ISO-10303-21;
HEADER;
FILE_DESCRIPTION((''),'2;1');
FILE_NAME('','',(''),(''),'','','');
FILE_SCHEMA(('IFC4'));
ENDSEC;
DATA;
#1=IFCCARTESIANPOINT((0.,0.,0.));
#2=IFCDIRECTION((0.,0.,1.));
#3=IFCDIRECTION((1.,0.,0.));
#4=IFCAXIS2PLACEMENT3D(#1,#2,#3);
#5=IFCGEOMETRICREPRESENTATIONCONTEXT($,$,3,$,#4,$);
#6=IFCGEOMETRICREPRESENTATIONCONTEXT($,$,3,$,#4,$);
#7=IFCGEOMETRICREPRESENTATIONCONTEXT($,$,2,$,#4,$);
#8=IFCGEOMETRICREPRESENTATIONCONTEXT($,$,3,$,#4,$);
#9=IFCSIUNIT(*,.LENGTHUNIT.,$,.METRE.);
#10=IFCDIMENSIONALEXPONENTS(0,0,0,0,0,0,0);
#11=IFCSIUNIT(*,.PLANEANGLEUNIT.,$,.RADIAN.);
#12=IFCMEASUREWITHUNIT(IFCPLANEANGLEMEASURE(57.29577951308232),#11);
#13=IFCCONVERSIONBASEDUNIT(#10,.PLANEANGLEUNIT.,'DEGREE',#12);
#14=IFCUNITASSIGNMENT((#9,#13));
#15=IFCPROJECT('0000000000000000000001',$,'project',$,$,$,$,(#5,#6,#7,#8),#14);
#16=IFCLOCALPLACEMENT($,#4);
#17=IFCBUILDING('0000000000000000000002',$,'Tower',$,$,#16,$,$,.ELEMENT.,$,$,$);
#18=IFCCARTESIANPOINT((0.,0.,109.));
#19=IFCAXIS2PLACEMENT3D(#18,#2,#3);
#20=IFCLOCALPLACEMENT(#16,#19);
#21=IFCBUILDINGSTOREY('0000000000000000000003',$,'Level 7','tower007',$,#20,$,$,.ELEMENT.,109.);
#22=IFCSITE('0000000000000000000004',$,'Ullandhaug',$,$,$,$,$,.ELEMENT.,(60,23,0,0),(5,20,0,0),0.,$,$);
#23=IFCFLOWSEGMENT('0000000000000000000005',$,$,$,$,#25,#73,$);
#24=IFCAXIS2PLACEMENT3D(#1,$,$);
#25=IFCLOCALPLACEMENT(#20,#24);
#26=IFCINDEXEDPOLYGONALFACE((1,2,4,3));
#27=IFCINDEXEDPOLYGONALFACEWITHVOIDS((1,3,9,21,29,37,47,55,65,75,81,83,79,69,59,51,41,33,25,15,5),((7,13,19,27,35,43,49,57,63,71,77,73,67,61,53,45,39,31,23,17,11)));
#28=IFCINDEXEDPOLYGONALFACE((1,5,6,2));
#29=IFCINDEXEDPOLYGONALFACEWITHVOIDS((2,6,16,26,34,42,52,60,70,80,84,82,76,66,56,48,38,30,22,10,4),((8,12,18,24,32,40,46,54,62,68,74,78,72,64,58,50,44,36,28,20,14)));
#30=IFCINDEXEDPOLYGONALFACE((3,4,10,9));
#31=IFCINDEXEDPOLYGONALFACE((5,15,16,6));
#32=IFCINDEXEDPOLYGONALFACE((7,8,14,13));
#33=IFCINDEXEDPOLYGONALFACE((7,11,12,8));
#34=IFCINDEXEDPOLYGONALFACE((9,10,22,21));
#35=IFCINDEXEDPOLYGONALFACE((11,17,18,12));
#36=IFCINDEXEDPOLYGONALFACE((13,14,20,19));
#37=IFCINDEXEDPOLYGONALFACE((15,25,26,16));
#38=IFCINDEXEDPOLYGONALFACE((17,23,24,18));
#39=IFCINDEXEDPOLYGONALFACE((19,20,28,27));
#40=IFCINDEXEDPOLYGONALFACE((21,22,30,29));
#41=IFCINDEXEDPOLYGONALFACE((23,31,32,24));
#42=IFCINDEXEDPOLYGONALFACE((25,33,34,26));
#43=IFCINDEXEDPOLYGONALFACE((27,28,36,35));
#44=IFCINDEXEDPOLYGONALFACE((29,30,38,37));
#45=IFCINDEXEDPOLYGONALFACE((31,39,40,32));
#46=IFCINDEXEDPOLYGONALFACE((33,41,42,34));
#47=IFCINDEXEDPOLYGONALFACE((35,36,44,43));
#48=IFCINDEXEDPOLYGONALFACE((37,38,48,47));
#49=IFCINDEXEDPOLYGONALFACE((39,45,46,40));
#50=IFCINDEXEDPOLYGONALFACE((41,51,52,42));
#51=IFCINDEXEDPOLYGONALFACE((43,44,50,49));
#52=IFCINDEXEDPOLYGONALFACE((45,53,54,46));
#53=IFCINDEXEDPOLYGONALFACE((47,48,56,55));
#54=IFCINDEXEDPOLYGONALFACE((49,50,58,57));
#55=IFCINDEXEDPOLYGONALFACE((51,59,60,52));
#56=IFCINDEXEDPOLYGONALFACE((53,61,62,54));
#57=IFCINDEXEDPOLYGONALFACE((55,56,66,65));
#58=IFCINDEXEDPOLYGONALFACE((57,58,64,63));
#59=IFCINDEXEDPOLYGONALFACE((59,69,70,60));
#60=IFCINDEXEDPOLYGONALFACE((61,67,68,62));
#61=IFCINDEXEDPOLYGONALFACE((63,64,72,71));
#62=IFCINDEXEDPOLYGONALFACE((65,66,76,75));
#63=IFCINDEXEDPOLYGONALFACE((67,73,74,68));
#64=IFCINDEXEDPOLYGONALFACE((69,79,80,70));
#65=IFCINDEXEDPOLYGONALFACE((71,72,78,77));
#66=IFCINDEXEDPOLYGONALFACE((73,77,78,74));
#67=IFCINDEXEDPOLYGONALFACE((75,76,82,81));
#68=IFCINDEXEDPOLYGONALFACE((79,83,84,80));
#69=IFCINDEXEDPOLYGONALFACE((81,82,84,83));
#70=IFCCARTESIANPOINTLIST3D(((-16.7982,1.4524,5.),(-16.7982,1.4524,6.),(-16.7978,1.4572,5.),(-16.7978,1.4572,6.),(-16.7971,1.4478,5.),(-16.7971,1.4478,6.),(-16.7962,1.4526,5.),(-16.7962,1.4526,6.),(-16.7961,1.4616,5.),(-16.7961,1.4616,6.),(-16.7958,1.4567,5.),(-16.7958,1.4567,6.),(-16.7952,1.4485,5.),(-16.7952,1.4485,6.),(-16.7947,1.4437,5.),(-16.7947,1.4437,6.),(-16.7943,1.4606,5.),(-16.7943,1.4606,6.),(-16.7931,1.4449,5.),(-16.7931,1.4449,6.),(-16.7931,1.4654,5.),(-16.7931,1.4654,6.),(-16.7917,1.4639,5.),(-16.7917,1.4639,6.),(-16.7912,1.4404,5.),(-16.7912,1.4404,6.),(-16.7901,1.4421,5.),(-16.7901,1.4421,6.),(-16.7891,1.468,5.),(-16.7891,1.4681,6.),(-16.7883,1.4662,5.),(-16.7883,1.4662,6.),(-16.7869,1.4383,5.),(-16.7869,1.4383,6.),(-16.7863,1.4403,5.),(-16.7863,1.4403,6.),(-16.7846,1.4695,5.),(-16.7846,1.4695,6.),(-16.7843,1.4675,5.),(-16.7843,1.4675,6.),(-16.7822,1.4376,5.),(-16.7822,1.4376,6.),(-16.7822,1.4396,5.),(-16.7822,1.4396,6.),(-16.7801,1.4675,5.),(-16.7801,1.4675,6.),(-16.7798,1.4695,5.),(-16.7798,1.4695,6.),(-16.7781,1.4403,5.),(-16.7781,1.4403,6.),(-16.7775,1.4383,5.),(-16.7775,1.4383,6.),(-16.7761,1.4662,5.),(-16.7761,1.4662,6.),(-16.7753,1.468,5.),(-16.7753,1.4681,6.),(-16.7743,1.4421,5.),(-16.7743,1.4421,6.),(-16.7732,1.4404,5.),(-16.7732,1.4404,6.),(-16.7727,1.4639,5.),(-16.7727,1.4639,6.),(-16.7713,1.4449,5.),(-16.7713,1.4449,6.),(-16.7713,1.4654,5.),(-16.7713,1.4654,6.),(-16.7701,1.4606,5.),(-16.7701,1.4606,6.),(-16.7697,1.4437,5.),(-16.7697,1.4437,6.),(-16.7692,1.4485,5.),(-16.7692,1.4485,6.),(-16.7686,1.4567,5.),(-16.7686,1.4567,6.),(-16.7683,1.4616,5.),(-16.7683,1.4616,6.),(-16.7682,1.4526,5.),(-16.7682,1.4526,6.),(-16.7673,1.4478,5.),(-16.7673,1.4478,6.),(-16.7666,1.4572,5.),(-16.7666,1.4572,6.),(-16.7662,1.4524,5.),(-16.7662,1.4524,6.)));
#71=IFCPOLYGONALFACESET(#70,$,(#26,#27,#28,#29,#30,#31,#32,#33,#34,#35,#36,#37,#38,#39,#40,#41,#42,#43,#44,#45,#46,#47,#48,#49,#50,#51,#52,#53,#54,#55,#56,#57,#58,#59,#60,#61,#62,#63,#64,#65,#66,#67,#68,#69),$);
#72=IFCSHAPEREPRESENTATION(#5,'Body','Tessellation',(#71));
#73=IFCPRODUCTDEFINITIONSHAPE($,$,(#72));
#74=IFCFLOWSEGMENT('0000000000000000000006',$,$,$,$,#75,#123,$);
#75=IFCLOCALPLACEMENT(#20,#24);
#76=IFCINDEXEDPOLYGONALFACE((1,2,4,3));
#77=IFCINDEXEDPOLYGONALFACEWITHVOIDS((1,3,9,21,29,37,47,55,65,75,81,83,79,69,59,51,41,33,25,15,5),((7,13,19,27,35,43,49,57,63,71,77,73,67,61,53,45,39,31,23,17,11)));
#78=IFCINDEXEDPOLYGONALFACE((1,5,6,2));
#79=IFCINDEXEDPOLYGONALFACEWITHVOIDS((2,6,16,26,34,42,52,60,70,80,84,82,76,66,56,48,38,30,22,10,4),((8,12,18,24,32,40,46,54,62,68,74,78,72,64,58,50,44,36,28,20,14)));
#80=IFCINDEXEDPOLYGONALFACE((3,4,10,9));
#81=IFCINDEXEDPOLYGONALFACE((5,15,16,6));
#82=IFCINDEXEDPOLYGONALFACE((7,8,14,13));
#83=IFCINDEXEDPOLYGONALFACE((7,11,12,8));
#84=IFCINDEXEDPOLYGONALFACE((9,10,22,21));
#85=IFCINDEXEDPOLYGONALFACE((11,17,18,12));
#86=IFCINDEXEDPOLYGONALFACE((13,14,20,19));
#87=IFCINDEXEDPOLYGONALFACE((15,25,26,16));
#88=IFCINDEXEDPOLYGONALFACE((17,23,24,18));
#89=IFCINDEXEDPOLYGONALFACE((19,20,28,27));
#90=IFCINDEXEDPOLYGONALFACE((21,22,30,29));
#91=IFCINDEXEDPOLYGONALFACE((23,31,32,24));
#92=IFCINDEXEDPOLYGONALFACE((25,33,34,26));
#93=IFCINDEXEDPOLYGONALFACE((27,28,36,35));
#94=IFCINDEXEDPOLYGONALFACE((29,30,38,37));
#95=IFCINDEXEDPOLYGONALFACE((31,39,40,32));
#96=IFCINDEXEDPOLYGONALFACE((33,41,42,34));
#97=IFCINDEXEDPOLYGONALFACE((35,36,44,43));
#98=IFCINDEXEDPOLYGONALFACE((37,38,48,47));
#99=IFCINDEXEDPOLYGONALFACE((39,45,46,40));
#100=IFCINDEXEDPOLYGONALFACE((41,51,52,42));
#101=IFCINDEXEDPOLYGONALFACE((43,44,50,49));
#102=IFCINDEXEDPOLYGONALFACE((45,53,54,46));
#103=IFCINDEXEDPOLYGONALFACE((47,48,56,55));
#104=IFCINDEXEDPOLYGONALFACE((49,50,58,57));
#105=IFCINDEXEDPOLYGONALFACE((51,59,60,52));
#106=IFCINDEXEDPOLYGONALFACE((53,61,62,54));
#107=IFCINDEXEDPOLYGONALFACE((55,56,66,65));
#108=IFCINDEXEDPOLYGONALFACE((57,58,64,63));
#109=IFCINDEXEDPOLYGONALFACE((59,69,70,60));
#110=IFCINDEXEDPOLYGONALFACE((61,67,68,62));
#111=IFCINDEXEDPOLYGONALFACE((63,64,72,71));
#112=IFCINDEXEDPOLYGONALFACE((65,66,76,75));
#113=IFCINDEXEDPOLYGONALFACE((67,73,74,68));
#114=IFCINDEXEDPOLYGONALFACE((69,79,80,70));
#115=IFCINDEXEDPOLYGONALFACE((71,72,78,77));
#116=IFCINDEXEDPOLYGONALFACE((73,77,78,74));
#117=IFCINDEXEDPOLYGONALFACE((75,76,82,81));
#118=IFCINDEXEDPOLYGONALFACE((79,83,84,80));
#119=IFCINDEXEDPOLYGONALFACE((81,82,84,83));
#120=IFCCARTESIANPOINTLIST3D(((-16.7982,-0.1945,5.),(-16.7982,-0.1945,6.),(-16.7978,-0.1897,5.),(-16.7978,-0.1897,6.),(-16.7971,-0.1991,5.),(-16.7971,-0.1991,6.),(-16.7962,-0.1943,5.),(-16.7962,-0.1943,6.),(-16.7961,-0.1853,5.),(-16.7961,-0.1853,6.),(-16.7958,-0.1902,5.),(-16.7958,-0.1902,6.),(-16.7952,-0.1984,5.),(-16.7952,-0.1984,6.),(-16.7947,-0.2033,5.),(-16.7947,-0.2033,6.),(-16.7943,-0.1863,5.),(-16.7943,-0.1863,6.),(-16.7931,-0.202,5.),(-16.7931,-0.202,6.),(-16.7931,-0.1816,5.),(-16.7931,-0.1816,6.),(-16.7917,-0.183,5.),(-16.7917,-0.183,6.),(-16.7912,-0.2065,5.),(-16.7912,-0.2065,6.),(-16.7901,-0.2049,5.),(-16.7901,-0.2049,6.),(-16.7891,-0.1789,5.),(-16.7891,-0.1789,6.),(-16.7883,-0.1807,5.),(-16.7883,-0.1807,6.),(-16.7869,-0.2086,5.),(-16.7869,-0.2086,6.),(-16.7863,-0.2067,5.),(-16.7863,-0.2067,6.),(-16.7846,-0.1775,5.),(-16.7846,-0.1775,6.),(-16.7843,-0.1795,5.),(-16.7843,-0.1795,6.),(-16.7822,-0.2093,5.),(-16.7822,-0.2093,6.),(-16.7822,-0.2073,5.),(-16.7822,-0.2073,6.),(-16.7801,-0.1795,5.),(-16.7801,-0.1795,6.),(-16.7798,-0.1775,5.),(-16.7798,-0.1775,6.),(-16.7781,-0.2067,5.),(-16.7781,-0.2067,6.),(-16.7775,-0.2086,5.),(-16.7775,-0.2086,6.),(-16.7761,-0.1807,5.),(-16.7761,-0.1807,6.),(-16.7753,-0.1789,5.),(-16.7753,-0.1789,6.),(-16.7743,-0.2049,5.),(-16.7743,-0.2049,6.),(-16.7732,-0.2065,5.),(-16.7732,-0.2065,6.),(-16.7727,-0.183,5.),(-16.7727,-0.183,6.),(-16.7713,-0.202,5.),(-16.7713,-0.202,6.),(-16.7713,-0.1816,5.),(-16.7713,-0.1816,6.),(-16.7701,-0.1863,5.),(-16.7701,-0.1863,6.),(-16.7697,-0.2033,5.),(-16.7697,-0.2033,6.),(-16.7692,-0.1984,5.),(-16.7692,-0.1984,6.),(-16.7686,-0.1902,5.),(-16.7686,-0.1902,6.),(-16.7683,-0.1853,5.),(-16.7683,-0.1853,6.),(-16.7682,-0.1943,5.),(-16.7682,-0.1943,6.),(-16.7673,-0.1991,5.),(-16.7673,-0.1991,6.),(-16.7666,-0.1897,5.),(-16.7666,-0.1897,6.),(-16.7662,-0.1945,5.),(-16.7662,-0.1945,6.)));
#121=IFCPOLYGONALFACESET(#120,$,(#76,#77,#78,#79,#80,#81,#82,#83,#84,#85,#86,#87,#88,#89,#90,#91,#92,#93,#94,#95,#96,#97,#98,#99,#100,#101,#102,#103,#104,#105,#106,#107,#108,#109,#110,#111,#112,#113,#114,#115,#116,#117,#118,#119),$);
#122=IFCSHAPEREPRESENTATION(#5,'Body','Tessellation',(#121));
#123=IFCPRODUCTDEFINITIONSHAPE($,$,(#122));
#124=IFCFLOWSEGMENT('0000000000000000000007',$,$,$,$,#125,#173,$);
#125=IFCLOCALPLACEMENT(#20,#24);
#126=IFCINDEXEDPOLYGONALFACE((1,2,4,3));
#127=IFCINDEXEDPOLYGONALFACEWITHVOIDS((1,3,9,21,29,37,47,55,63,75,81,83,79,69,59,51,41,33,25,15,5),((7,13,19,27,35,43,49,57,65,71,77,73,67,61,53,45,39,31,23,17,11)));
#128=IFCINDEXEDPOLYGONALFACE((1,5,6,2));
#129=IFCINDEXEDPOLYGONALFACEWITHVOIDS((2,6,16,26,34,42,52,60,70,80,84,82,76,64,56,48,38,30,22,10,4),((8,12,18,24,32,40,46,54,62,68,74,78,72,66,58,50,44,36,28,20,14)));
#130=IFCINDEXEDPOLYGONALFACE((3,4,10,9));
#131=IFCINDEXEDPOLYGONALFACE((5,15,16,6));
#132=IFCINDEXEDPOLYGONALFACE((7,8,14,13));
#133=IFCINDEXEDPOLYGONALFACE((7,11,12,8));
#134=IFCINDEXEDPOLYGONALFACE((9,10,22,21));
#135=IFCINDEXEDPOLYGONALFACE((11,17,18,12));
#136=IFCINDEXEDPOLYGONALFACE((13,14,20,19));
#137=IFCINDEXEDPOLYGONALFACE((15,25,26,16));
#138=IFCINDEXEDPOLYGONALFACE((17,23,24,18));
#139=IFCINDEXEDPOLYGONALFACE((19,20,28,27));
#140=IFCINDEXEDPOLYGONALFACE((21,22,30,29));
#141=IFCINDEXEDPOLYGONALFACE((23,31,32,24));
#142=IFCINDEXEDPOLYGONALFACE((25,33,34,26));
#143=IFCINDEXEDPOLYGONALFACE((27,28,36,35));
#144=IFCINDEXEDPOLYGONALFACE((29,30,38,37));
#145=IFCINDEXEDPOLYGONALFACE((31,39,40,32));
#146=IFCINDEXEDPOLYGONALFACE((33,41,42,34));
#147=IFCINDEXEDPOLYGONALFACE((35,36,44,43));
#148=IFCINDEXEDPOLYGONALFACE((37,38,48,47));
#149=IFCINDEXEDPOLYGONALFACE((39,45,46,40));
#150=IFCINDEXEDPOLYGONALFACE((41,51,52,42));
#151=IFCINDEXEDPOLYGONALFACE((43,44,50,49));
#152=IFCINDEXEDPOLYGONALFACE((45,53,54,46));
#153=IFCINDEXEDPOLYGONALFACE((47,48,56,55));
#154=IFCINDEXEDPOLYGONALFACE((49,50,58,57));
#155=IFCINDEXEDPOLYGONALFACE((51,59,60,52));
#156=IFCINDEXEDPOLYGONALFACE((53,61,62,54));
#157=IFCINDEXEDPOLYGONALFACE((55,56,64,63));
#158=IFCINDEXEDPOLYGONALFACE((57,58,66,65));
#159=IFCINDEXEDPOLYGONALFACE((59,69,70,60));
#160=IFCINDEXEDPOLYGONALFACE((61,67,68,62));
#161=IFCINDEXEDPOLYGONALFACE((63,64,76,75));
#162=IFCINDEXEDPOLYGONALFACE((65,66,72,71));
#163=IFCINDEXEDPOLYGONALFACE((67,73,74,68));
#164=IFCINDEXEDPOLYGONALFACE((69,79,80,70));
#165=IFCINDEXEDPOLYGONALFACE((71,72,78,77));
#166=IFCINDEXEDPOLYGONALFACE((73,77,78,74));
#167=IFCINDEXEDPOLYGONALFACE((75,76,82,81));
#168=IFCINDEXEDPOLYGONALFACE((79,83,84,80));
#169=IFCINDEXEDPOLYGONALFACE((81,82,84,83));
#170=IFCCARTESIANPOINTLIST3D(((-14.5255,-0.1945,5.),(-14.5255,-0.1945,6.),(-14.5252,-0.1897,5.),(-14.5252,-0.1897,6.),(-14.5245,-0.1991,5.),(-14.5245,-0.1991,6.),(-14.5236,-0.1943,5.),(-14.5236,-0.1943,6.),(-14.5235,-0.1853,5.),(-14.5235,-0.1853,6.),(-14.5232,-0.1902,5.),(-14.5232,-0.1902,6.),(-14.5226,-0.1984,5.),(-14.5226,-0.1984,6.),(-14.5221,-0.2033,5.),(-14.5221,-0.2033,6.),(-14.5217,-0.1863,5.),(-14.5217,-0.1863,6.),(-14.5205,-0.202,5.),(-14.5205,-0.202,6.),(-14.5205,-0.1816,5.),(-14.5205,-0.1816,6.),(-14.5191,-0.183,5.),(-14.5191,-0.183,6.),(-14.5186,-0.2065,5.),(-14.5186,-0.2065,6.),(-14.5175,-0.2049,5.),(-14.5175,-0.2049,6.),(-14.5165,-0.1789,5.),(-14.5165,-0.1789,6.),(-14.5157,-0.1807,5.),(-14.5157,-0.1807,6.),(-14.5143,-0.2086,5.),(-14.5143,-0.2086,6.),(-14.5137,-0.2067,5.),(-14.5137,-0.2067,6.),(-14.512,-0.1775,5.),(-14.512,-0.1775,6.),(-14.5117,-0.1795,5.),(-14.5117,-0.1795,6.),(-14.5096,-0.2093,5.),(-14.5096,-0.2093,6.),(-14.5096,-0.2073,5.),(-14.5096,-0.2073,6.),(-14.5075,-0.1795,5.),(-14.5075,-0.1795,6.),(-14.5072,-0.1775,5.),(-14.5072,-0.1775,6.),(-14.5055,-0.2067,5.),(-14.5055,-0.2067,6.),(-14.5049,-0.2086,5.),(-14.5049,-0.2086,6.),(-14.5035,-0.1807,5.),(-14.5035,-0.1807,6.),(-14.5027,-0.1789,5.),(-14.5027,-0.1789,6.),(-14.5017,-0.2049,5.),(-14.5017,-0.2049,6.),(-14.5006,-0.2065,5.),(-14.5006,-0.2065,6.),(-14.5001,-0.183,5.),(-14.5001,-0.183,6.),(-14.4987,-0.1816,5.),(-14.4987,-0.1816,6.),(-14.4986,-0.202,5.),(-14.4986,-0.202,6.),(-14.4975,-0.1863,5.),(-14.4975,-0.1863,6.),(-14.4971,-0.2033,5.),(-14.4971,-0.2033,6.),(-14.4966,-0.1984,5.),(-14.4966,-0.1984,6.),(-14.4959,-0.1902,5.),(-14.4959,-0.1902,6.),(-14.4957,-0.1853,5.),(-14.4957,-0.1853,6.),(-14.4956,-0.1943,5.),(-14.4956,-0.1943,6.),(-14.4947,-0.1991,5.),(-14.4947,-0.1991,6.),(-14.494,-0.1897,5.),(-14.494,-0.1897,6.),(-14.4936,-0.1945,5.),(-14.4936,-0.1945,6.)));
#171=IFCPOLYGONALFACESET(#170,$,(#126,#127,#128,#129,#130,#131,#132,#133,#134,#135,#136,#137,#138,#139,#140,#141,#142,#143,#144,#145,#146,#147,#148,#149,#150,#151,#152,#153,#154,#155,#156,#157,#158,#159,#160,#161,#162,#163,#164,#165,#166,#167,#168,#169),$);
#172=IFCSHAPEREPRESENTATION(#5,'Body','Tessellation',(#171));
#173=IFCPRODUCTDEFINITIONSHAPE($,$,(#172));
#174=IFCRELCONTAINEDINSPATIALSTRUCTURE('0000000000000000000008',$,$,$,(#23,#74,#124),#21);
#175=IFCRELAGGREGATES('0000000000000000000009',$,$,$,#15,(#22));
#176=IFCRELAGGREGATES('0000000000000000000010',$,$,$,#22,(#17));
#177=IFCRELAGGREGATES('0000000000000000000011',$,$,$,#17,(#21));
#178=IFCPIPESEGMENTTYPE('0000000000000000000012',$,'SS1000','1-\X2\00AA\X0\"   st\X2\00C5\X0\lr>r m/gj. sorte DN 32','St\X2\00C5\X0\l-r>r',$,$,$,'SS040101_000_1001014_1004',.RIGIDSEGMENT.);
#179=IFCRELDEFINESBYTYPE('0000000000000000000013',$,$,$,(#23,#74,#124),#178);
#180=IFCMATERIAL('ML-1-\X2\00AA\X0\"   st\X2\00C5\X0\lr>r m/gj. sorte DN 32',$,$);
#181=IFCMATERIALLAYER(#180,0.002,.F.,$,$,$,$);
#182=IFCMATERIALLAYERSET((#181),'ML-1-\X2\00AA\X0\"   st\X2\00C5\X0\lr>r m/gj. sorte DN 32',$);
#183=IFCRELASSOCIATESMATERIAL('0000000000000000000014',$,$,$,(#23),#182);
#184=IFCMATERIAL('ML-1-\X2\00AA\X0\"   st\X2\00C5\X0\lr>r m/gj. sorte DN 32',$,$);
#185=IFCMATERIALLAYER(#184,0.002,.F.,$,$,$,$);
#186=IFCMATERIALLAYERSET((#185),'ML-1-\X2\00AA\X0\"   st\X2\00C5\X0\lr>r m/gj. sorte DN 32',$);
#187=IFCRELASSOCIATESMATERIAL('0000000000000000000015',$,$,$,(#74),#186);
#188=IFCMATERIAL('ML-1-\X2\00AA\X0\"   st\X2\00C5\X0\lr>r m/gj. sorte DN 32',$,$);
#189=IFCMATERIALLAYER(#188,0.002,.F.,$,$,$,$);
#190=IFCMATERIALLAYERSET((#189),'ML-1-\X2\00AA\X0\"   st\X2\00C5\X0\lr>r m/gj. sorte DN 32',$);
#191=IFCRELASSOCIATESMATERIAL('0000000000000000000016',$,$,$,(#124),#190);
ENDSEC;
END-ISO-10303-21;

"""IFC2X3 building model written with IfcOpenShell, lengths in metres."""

from ifc_helpers import new_model, entity, si_unit, converted_unit, frame, origin_with_axes, origin_2d_with_axis, place, context, project, spatial, hollow_circle, extrude, material, layer, layer_set, layer_usage, type_object, element, save


model = new_model("IFC2X3")

# Units and contexts
context_of_model_1 = context(None, 3, world=origin_with_axes())
context_of_model_2 = context(None, 3, world=origin_with_axes())
context_of_model_3 = context(None, 2, world=origin_with_axes())
context_of_model_4 = context(None, 3, world=origin_with_axes())
ifc_project = project(units=[si_unit("LENGTHUNIT", "METRE"), converted_unit("PLANEANGLEUNIT", "DEGREE", entity("IfcPlaneAngleMeasure", 57.29577951308232), si_unit("PLANEANGLEUNIT", "RADIAN"), dimensions=[0, 0, 0, 0, 0, 0, 0])], contexts=[context_of_model_1, context_of_model_2, context_of_model_3, context_of_model_4])

# Site, building, storey
site = spatial("IfcSite", under=ifc_project, Name="Ullandhaug", CompositionType="ELEMENT", RefLatitude=(60, 23, 0, 0), RefLongitude=(5, 20, 0, 0), RefElevation=0.0)
building_placement = place(None, origin_with_axes())
building = spatial("IfcBuilding", under=site, at=building_placement, Name="Tower", CompositionType="ELEMENT")
storey_placement = place(building_placement, frame((0.0, 0.0, 109.0), z_axis=(0.0, 0.0, 1.0), x_axis=(1.0, 0.0, 0.0)))
storey = spatial("IfcBuildingStorey", under=building, at=storey_placement, Name="Level 7", Description="tower007", CompositionType="ELEMENT", Elevation=109.0)

# Flow segments
pipe_segment_type_1 = type_object("IfcPipeSegmentType", Name="SS1000", Description="1-ª\"   stÅlr>r m/gj. sorte DN 32", ApplicableOccurrence="StÅl-r>r", ElementType="SS040101_000_1001014_1004", PredefinedType="RIGIDSEGMENT")
ifc_material_1 = material(Name="ML-1-ª\"   stÅlr>r m/gj. sorte DN 32")
ifc_layer_1 = layer(ifc_material_1, 0.002, ventilated=False)
ifc_layer_set_1 = layer_set([ifc_layer_1], Name="ML-1-ª\"   stÅlr>r m/gj. sorte DN 32")
ifc_layer_usage_1 = layer_usage(ifc_layer_set_1, "AXIS2", "POSITIVE", 0.0)
flow_segment_1_placement = place(storey_placement, frame((-16.7822, 1.4536, 5.0), z_axis=(0.0, 0.0, 1.0), x_axis=(0.0, -1.0, 0.0)))
element("IfcFlowSegment", 1, at=flow_segment_1_placement, inside=storey, type_object=pipe_segment_type_1, material=ifc_layer_usage_1, context=context_of_model_1, shape_type="SweptSolid", body=[
    extrude(hollow_circle(Radius=0.016, WallThickness=0.002, at=origin_2d_with_axis()), origin_with_axes(), (0.0, 0.0, 1.0), 1.0),
])
ifc_material_2 = material(Name="ML-1-ª\"   stÅlr>r m/gj. sorte DN 32")
ifc_layer_2 = layer(ifc_material_2, 0.002, ventilated=False)
ifc_layer_set_2 = layer_set([ifc_layer_2], Name="ML-1-ª\"   stÅlr>r m/gj. sorte DN 32")
ifc_layer_usage_2 = layer_usage(ifc_layer_set_2, "AXIS2", "POSITIVE", 0.0)
flow_segment_2_placement = place(storey_placement, frame((-16.7822, -0.1933, 5.0), z_axis=(0.0, 0.0, 1.0), x_axis=(0.0, -1.0, 0.0)))
element("IfcFlowSegment", 2, at=flow_segment_2_placement, inside=storey, type_object=pipe_segment_type_1, material=ifc_layer_usage_2, context=context_of_model_1, shape_type="SweptSolid", body=[
    extrude(hollow_circle(Radius=0.016, WallThickness=0.002, at=origin_2d_with_axis()), origin_with_axes(), (0.0, 0.0, 1.0), 1.0),
])
ifc_material_3 = material(Name="ML-1-ª\"   stÅlr>r m/gj. sorte DN 32")
ifc_layer_3 = layer(ifc_material_3, 0.002, ventilated=False)
ifc_layer_set_3 = layer_set([ifc_layer_3], Name="ML-1-ª\"   stÅlr>r m/gj. sorte DN 32")
ifc_layer_usage_3 = layer_usage(ifc_layer_set_3, "AXIS2", "POSITIVE", 0.0)
flow_segment_3_placement = place(storey_placement, frame((-14.5096, -0.1933, 5.0), z_axis=(0.0, 0.0, 1.0), x_axis=(0.0, -1.0, 0.0)))
element("IfcFlowSegment", 3, at=flow_segment_3_placement, inside=storey, type_object=pipe_segment_type_1, material=ifc_layer_usage_3, context=context_of_model_1, shape_type="SweptSolid", body=[
    extrude(hollow_circle(Radius=0.016, WallThickness=0.002, at=origin_2d_with_axis()), origin_with_axes(), (0.0, 0.0, 1.0), 1.0),
])

save(model, "model.ifc")
